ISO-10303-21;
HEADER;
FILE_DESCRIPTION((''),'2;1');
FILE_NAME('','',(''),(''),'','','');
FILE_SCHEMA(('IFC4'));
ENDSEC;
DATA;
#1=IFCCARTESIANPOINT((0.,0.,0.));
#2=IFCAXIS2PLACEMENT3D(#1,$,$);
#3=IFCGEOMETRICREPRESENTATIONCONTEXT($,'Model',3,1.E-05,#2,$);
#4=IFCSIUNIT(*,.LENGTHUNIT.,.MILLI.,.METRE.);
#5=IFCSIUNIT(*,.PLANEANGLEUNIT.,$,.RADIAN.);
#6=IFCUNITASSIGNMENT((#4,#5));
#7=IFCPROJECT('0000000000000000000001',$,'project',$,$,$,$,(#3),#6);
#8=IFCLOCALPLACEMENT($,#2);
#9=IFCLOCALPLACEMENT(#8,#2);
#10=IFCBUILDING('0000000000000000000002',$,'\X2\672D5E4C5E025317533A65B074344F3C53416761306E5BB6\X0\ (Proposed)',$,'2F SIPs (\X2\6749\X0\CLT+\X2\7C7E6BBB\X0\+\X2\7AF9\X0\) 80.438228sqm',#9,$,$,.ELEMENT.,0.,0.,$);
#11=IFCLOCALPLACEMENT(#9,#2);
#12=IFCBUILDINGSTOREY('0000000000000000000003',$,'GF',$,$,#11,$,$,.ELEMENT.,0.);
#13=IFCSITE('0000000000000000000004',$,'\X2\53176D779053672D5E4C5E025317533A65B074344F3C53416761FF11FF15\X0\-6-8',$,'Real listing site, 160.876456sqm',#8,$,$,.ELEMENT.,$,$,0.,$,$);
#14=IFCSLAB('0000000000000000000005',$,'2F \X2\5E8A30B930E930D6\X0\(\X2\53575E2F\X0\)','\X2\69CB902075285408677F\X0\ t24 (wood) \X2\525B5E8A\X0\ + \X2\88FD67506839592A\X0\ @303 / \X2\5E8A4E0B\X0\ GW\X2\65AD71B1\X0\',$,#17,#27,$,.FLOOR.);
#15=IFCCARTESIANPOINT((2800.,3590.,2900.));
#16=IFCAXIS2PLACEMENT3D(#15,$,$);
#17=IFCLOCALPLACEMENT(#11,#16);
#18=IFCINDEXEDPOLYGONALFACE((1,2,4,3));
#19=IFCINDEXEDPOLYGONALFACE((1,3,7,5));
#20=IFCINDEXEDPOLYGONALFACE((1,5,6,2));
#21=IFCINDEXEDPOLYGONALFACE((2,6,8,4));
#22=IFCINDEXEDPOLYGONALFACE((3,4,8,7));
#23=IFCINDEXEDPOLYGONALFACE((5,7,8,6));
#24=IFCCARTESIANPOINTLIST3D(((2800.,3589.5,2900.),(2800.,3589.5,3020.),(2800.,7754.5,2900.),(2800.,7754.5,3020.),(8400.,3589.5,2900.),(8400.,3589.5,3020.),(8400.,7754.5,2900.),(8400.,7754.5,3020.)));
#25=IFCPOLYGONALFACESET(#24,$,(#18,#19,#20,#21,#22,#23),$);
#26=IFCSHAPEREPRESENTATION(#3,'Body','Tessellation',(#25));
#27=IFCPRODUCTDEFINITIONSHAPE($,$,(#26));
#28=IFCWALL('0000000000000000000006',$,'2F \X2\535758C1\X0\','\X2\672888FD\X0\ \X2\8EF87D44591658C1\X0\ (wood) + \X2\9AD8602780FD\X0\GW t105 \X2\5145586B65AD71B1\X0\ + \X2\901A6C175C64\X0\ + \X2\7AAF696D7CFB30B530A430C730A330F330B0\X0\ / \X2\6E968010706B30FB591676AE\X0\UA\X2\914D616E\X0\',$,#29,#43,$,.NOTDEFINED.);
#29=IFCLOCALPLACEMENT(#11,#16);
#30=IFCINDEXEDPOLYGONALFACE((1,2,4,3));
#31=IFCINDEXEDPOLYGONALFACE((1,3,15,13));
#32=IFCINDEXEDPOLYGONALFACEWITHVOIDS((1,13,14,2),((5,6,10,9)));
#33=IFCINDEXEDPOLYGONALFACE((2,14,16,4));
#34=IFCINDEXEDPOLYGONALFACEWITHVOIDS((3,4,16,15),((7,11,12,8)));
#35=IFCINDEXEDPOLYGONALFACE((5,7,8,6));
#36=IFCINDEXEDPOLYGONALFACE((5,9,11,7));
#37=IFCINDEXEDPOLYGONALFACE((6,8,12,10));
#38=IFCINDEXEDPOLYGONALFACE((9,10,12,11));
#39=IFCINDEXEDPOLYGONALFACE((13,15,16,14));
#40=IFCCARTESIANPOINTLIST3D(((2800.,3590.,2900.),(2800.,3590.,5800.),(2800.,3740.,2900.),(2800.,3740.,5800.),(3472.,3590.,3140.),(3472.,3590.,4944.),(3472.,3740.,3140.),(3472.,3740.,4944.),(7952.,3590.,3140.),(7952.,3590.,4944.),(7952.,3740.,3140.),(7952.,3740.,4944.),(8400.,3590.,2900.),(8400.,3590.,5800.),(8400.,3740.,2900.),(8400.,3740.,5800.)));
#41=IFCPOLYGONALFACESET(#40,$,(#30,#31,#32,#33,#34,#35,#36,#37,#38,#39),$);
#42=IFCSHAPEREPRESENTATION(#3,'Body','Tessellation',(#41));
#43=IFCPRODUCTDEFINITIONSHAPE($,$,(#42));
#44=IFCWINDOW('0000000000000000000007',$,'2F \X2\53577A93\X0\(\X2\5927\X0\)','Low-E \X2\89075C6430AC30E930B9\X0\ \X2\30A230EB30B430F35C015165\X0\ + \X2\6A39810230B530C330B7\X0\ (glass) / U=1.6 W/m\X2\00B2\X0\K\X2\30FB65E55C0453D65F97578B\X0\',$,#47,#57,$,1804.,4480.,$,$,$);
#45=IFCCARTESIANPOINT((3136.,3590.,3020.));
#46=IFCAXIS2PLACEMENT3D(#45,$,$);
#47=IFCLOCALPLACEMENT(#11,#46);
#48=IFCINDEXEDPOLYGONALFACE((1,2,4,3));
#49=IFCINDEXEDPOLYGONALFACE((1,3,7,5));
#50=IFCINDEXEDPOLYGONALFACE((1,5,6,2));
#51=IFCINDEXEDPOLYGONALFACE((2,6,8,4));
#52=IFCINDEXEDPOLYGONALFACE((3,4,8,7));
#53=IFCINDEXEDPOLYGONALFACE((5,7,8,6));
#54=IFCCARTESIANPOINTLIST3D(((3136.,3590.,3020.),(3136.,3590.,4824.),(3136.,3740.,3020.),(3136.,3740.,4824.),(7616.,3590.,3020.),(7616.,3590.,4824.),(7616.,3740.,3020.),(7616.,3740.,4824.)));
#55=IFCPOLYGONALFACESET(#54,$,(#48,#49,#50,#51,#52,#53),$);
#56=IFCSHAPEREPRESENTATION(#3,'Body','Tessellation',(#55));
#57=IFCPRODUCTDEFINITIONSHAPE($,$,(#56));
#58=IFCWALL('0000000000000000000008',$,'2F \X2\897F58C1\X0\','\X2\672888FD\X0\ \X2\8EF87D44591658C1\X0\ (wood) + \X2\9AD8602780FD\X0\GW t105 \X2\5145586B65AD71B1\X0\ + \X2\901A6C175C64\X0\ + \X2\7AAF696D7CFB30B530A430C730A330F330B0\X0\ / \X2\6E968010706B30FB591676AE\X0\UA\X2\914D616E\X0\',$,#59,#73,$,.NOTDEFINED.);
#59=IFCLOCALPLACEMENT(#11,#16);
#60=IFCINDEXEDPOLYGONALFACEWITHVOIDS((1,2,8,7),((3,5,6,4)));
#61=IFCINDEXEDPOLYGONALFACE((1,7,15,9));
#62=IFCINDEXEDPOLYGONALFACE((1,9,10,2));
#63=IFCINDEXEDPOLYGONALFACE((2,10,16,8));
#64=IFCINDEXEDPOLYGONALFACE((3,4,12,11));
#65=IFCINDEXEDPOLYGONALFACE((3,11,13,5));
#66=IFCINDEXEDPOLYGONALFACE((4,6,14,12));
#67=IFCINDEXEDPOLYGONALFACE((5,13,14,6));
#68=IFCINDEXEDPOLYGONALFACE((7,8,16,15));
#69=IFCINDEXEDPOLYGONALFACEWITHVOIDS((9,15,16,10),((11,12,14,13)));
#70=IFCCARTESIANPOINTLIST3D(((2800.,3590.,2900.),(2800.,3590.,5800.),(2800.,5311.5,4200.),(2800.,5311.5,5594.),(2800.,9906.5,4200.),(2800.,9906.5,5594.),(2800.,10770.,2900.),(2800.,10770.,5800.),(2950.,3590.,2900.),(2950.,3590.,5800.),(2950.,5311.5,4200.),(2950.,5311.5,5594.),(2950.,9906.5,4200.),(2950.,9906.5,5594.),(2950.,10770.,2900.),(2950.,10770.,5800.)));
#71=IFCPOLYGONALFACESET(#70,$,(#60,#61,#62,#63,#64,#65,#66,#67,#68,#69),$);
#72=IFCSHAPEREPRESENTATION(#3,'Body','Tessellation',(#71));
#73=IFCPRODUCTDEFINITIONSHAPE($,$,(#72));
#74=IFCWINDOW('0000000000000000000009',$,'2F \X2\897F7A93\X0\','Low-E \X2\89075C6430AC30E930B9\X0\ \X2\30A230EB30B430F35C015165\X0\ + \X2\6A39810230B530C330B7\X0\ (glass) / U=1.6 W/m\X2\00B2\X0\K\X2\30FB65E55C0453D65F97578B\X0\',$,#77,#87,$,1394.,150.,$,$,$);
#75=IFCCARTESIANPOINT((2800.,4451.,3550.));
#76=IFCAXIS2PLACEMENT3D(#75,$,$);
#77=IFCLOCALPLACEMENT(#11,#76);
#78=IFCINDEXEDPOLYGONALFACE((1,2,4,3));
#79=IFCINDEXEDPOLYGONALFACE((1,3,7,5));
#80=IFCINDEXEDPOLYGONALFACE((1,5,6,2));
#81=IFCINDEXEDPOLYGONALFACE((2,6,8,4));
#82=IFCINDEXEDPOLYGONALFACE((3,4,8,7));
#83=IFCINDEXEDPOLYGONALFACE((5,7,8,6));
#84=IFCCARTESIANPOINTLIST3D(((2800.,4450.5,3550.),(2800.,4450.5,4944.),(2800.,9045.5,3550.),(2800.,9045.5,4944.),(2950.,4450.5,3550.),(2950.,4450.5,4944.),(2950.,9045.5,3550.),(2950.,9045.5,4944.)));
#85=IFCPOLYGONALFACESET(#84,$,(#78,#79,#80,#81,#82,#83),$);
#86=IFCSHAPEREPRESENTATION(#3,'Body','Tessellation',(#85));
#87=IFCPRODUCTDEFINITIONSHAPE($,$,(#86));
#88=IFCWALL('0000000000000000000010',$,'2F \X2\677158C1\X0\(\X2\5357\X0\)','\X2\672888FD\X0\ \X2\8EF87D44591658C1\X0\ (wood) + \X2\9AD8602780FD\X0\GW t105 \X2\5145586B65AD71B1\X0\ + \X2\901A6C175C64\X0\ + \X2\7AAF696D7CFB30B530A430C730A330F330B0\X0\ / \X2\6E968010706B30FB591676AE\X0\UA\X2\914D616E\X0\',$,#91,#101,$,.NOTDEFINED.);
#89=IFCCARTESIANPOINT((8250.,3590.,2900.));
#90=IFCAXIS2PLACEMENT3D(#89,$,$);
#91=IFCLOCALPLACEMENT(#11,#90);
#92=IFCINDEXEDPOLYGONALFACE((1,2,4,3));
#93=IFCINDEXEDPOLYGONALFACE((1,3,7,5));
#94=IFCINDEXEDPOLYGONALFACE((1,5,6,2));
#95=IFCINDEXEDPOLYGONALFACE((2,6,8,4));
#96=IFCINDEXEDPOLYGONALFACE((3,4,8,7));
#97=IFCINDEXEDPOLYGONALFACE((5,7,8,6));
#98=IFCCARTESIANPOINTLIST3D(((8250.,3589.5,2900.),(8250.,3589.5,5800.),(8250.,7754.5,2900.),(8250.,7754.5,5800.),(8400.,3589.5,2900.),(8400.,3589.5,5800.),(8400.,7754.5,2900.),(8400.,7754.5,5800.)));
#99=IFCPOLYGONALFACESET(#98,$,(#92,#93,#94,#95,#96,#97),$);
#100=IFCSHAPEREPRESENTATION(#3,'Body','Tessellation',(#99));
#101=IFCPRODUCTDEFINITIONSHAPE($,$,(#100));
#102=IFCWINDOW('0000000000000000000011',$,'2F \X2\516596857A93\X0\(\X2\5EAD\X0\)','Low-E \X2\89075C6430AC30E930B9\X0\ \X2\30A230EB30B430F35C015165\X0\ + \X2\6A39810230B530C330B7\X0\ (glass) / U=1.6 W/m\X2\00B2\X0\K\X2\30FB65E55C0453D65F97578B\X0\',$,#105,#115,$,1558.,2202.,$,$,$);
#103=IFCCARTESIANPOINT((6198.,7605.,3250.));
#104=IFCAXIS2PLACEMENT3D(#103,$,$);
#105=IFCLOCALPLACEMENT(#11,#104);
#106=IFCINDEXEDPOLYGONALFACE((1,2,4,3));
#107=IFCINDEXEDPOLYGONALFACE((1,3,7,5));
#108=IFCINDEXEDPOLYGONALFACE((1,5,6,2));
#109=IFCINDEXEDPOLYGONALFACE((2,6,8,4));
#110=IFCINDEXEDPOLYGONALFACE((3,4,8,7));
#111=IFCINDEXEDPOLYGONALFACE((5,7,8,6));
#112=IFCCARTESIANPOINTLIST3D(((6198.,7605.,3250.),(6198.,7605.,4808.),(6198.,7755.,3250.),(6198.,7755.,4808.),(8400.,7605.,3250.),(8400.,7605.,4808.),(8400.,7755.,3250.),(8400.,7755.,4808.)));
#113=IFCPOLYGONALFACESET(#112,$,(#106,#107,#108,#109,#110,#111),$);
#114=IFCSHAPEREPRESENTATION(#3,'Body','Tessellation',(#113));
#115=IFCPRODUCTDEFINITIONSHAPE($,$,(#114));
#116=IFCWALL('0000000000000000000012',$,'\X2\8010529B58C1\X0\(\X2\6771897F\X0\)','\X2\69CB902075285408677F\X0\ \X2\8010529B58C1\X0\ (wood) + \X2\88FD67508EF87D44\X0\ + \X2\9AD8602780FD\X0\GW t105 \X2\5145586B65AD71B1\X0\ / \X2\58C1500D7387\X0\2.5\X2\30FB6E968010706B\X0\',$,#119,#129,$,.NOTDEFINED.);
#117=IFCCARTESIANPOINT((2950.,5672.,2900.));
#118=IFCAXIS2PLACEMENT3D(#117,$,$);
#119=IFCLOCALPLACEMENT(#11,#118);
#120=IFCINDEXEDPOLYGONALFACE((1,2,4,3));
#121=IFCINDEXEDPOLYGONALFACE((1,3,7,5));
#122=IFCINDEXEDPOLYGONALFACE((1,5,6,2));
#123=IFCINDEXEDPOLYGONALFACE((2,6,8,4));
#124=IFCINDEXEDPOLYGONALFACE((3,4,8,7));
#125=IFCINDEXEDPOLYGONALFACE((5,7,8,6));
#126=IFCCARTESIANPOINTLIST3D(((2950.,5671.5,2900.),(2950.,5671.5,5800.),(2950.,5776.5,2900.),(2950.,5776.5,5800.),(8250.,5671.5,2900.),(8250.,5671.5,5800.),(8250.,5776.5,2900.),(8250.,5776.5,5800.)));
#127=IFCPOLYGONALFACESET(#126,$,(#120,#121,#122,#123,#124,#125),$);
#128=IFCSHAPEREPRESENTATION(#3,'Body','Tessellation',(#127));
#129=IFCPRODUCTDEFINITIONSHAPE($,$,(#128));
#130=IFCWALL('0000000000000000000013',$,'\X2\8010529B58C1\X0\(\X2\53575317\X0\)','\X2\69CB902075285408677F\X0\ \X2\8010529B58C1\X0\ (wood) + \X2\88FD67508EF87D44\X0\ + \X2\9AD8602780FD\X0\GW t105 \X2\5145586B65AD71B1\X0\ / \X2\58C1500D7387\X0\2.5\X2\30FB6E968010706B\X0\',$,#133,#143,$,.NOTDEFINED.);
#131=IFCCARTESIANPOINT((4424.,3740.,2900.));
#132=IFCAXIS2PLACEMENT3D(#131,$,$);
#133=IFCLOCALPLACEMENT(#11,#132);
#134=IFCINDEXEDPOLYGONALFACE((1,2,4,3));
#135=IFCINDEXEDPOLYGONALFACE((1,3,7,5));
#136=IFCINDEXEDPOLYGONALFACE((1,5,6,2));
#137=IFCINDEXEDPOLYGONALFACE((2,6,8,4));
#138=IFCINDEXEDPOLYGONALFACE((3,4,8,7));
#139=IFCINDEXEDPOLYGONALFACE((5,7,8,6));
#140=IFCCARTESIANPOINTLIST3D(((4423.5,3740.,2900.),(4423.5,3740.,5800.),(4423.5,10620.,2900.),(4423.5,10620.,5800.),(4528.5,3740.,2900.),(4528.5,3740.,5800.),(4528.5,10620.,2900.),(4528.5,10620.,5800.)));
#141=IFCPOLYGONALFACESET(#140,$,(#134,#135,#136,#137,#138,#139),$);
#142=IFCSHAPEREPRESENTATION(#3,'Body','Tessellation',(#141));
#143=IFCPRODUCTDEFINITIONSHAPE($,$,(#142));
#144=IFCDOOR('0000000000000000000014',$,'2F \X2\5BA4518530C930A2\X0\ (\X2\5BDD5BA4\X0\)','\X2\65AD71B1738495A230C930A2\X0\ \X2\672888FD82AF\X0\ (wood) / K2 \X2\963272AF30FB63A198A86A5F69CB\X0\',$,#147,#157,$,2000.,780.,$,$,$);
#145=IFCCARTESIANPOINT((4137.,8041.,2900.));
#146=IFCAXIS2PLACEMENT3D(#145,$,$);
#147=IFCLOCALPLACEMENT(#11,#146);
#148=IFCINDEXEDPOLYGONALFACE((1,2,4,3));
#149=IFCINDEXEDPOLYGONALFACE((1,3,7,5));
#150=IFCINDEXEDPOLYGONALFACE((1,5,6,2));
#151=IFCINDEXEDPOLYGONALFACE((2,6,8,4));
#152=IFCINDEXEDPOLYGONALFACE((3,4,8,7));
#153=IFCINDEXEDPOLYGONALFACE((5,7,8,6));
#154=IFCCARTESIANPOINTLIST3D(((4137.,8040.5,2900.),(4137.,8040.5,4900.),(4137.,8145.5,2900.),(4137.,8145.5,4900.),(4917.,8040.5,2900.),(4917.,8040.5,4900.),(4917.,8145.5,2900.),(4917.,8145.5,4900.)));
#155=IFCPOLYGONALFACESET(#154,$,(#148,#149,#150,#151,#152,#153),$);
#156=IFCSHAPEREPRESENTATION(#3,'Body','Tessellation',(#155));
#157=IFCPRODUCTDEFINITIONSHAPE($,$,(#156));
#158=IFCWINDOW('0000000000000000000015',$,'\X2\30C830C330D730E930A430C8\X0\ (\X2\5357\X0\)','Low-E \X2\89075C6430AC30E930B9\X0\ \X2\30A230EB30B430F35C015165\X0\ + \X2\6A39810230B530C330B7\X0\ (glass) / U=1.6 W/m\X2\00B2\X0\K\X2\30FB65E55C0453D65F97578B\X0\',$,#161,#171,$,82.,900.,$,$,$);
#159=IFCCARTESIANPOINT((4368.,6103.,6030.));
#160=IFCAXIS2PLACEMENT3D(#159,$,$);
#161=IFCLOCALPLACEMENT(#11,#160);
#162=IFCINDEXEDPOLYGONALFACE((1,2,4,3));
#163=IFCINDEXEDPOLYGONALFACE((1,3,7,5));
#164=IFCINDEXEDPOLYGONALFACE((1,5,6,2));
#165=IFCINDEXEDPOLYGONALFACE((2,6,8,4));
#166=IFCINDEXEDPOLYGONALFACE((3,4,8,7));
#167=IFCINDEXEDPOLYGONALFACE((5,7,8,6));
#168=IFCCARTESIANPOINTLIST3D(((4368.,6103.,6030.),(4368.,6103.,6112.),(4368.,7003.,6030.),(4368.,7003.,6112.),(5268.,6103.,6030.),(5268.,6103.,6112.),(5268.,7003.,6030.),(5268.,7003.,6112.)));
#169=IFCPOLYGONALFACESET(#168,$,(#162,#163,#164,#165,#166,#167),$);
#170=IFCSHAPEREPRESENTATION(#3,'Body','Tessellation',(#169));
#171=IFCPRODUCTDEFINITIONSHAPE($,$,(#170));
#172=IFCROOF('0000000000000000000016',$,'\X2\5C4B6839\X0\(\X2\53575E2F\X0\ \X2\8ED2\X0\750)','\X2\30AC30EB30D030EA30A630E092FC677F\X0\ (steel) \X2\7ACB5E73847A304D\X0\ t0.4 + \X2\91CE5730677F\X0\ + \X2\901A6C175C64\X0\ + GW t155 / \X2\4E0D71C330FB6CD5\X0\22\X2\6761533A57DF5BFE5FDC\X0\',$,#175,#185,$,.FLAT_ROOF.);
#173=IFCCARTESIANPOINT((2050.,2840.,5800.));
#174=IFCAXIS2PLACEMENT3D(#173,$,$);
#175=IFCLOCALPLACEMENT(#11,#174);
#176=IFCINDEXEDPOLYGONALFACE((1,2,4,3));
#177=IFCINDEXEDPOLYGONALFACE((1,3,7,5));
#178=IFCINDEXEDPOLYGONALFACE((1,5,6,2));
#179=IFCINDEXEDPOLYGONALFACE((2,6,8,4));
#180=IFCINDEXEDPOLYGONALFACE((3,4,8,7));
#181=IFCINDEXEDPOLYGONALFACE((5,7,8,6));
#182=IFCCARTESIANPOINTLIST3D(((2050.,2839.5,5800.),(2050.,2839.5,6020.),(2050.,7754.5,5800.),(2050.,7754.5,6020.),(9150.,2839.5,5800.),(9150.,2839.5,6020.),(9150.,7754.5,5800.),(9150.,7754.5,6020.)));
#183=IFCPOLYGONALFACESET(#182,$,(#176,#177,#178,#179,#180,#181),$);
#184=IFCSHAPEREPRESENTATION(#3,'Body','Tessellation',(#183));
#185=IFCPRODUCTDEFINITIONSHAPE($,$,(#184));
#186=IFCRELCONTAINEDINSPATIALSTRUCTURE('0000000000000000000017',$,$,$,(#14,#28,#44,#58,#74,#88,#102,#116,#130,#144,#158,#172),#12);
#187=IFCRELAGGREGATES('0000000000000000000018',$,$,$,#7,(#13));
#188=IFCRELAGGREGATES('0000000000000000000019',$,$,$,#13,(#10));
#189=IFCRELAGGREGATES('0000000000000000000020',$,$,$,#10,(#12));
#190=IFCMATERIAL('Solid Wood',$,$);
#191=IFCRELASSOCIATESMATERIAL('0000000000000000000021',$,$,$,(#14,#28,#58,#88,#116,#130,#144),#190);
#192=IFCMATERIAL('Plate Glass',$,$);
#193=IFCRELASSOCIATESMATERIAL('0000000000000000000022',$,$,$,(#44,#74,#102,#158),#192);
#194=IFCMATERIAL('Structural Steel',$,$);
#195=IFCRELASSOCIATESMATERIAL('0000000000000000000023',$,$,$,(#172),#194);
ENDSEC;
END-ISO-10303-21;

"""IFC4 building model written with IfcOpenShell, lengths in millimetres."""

from ifc_helpers import new_model, si_unit, frame, frame_2d, origin, place, context, project, spatial, rectangle, extrude, material, element, fill, save


model = new_model("IFC4")

# Units and contexts
model_context = context("Model", 3, precision=1e-05, world=origin())
ifc_project = project(units=[si_unit("LENGTHUNIT", "METRE", prefix="MILLI"), si_unit("PLANEANGLEUNIT", "RADIAN")], contexts=[model_context])

# Site, building, storey
site_placement = place(None, origin())
site = spatial("IfcSite", under=ifc_project, at=site_placement, Name="北海道札幌市北区新琴似十条１５-6-8", ObjectType="Real listing site, 160.876456sqm", CompositionType="ELEMENT", RefElevation=0.0)
building_placement = place(site_placement, origin())
building = spatial("IfcBuilding", under=site, at=building_placement, Name="札幌市北区新琴似十条の家 (Proposed)", ObjectType="2F SIPs (杉CLT+籾殻+竹) 80.438228sqm", CompositionType="ELEMENT", ElevationOfRefHeight=0.0, ElevationOfTerrain=0.0)
storey_placement = place(building_placement, origin())
storey = spatial("IfcBuildingStorey", under=building, at=storey_placement, Name="GF", CompositionType="ELEMENT", Elevation=0.0)

# Slab
ifc_material_1 = material(Name="Solid Wood")
slab_placement = place(storey_placement, frame((2800.0, 3590.0, 2900.0)))
element("IfcSlab", 1, at=slab_placement, inside=storey, material=ifc_material_1, Name="2F 床スラブ(南帯)", Description="構造用合板 t24 (wood) 剛床 + 製材根太 @303 / 床下 GW断熱", PredefinedType="FLOOR", context=model_context, shape_type="SweptSolid", body=[
    extrude(rectangle(XDim=5600.0, YDim=4165.0, at=frame_2d((2800.0, 2082.0))), frame((2800.0, 3590.0, 2900.0)), (0.0, 0.0, 1.0), 120.0),
])

# Walls, openings, windows
wall_1_placement = place(storey_placement, frame((2800.0, 3590.0, 2900.0)))
wall_1 = element("IfcWall", 2, at=wall_1_placement, inside=storey, material=ifc_material_1, Name="2F 南壁", Description="木製 軸組外壁 (wood) + 高性能GW t105 充填断熱 + 通気層 + 窯業系サイディング / 準耐火・外皮UA配慮", PredefinedType="NOTDEFINED", context=model_context, shape_type="SweptSolid", body=[
    extrude(rectangle(XDim=5600.0, YDim=150.0, at=frame_2d((2800.0, 75.0))), frame((2800.0, 3590.0, 2900.0)), (0.0, 0.0, 1.0), 2900.0),
])
opening_1_placement = place(storey_placement, frame((3136.0, 3590.0, 3020.0)))
opening_1 = element("IfcOpeningElement", 3, at=opening_1_placement, cuts=wall_1, PredefinedType="NOTDEFINED", context=model_context, shape_type="SweptSolid", body=[
    extrude(rectangle(XDim=4480.0, YDim=150.0, at=frame_2d((2240.0, 75.0))), frame((3136.0, 3590.0, 3020.0)), (0.0, 0.0, 1.0), 1804.0),
])
ifc_material_2 = material(Name="Plate Glass")
window_1_placement = place(storey_placement, frame((3136.0, 3590.0, 3020.0)))
window_1 = element("IfcWindow", 4, at=window_1_placement, inside=storey, material=ifc_material_2, Name="2F 南窓(大)", Description="Low-E 複層ガラス アルゴン封入 + 樹脂サッシ (glass) / U=1.6 W/m²K・日射取得型", OverallHeight=1804.0, OverallWidth=4480.0, context=model_context, shape_type="SweptSolid", body=[
    extrude(rectangle(XDim=4480.0, YDim=150.0, at=frame_2d((2240.0, 75.0))), frame((3136.0, 3590.0, 3020.0)), (0.0, 0.0, 1.0), 1804.0),
])
fill(opening_1, window_1)
wall_2_placement = place(storey_placement, frame((2800.0, 3590.0, 2900.0)))
wall_2 = element("IfcWall", 5, at=wall_2_placement, inside=storey, material=ifc_material_1, Name="2F 西壁", Description="木製 軸組外壁 (wood) + 高性能GW t105 充填断熱 + 通気層 + 窯業系サイディング / 準耐火・外皮UA配慮", PredefinedType="NOTDEFINED", context=model_context, shape_type="SweptSolid", body=[
    extrude(rectangle(XDim=150.0, YDim=7180.0, at=frame_2d((75.0, 3590.0))), frame((2800.0, 3590.0, 2900.0)), (0.0, 0.0, 1.0), 2900.0),
])
opening_2_placement = place(storey_placement, frame((2800.0, 4451.0, 3550.0)))
opening_2 = element("IfcOpeningElement", 6, at=opening_2_placement, cuts=wall_2, PredefinedType="NOTDEFINED", context=model_context, shape_type="SweptSolid", body=[
    extrude(rectangle(XDim=150.0, YDim=4595.0, at=frame_2d((75.0, 2297.0))), frame((2800.0, 4451.0, 3550.0)), (0.0, 0.0, 1.0), 1394.0),
])
window_2_placement = place(storey_placement, frame((2800.0, 4451.0, 3550.0)))
window_2 = element("IfcWindow", 7, at=window_2_placement, inside=storey, material=ifc_material_2, Name="2F 西窓", Description="Low-E 複層ガラス アルゴン封入 + 樹脂サッシ (glass) / U=1.6 W/m²K・日射取得型", OverallHeight=1394.0, OverallWidth=150.0, context=model_context, shape_type="SweptSolid", body=[
    extrude(rectangle(XDim=150.0, YDim=4595.0, at=frame_2d((75.0, 2297.0))), frame((2800.0, 4451.0, 3550.0)), (0.0, 0.0, 1.0), 1394.0),
])
fill(opening_2, window_2)
wall_3_placement = place(storey_placement, frame((8250.0, 3590.0, 2900.0)))
wall_3 = element("IfcWall", 8, at=wall_3_placement, inside=storey, material=ifc_material_1, Name="2F 東壁(南)", Description="木製 軸組外壁 (wood) + 高性能GW t105 充填断熱 + 通気層 + 窯業系サイディング / 準耐火・外皮UA配慮", PredefinedType="NOTDEFINED", context=model_context, shape_type="SweptSolid", body=[
    extrude(rectangle(XDim=150.0, YDim=4165.0, at=frame_2d((75.0, 2082.0))), frame((8250.0, 3590.0, 2900.0)), (0.0, 0.0, 1.0), 2900.0),
])
opening_3_placement = place(storey_placement, frame((6198.0, 7605.0, 3250.0)))
opening_3 = element("IfcOpeningElement", 9, at=opening_3_placement, cuts=wall_3, PredefinedType="NOTDEFINED", context=model_context, shape_type="SweptSolid", body=[
    extrude(rectangle(XDim=2202.0, YDim=150.0, at=frame_2d((1101.0, 75.0))), frame((6198.0, 7605.0, 3250.0)), (0.0, 0.0, 1.0), 1558.0),
])
window_3_placement = place(storey_placement, frame((6198.0, 7605.0, 3250.0)))
window_3 = element("IfcWindow", 10, at=window_3_placement, inside=storey, material=ifc_material_2, Name="2F 入隅窓(庭)", Description="Low-E 複層ガラス アルゴン封入 + 樹脂サッシ (glass) / U=1.6 W/m²K・日射取得型", OverallHeight=1558.0, OverallWidth=2202.0, context=model_context, shape_type="SweptSolid", body=[
    extrude(rectangle(XDim=2202.0, YDim=150.0, at=frame_2d((1101.0, 75.0))), frame((6198.0, 7605.0, 3250.0)), (0.0, 0.0, 1.0), 1558.0),
])
fill(opening_3, window_3)

# Wall
wall_4_placement = place(storey_placement, frame((2950.0, 5672.0, 2900.0)))
element("IfcWall", 11, at=wall_4_placement, inside=storey, material=ifc_material_1, Name="耐力壁(東西)", Description="構造用合板 耐力壁 (wood) + 製材軸組 + 高性能GW t105 充填断熱 / 壁倍率2.5・準耐火", PredefinedType="NOTDEFINED", context=model_context, shape_type="SweptSolid", body=[
    extrude(rectangle(XDim=5300.0, YDim=105.0, at=frame_2d((2650.0, 52.0))), frame((2950.0, 5672.0, 2900.0)), (0.0, 0.0, 1.0), 2900.0),
])

# Wall, opening, door
wall_5_placement = place(storey_placement, frame((4424.0, 3740.0, 2900.0)))
wall_5 = element("IfcWall", 12, at=wall_5_placement, inside=storey, material=ifc_material_1, Name="耐力壁(南北)", Description="構造用合板 耐力壁 (wood) + 製材軸組 + 高性能GW t105 充填断熱 / 壁倍率2.5・準耐火", PredefinedType="NOTDEFINED", context=model_context, shape_type="SweptSolid", body=[
    extrude(rectangle(XDim=105.0, YDim=6880.0, at=frame_2d((52.0, 3440.0))), frame((4424.0, 3740.0, 2900.0)), (0.0, 0.0, 1.0), 2900.0),
])
opening_4_placement = place(storey_placement, frame((4137.0, 8041.0, 2900.0)))
opening_4 = element("IfcOpeningElement", 13, at=opening_4_placement, cuts=wall_5, PredefinedType="NOTDEFINED", context=model_context, shape_type="SweptSolid", body=[
    extrude(rectangle(XDim=780.0, YDim=105.0, at=frame_2d((390.0, 52.0))), frame((4137.0, 8041.0, 2900.0)), (0.0, 0.0, 1.0), 2000.0),
])
door_placement = place(storey_placement, frame((4137.0, 8041.0, 2900.0)))
door = element("IfcDoor", 14, at=door_placement, inside=storey, material=ifc_material_1, Name="2F 室内ドア (寝室)", Description="断熱玄関ドア 木製芯 (wood) / K2 防犯・採風機構", OverallHeight=2000.0, OverallWidth=780.0, context=model_context, shape_type="SweptSolid", body=[
    extrude(rectangle(XDim=780.0, YDim=105.0, at=frame_2d((390.0, 52.0))), frame((4137.0, 8041.0, 2900.0)), (0.0, 0.0, 1.0), 2000.0),
])
fill(opening_4, door)

# Window
window_4_placement = place(storey_placement, frame((4368.0, 6103.0, 6030.0)))
element("IfcWindow", 15, at=window_4_placement, inside=storey, material=ifc_material_2, Name="トップライト (南)", Description="Low-E 複層ガラス アルゴン封入 + 樹脂サッシ (glass) / U=1.6 W/m²K・日射取得型", OverallHeight=82.0, OverallWidth=900.0, context=model_context, shape_type="SweptSolid", body=[
    extrude(rectangle(XDim=900.0, YDim=900.0, at=frame_2d((450.0, 450.0))), frame((4368.0, 6103.0, 6030.0)), (0.0, 0.0, 1.0), 82.0),
])

# Roof
ifc_material_3 = material(Name="Structural Steel")
for number, where, name in (
    (16, (2050.0, 2840.0, 5800.0), "屋根(南帯 軒750)"),
):
    element("IfcRoof", number, at=place(storey_placement, frame(where)), inside=storey, material=ifc_material_3, Name=name, Description="ガルバリウム鋼板 (steel) 立平葺き t0.4 + 野地板 + 通気層 + GW t155 / 不燃・法22条区域対応", PredefinedType="FLAT_ROOF", context=model_context, shape_type="SweptSolid", body=[
        extrude(rectangle(XDim=7100.0, YDim=4915.0, at=frame_2d((3550.0, 2457.0))), frame((2050.0, 2840.0, 5800.0)), (0.0, 0.0, 1.0), 220.0),
    ])

save(model, "model.ifc")
